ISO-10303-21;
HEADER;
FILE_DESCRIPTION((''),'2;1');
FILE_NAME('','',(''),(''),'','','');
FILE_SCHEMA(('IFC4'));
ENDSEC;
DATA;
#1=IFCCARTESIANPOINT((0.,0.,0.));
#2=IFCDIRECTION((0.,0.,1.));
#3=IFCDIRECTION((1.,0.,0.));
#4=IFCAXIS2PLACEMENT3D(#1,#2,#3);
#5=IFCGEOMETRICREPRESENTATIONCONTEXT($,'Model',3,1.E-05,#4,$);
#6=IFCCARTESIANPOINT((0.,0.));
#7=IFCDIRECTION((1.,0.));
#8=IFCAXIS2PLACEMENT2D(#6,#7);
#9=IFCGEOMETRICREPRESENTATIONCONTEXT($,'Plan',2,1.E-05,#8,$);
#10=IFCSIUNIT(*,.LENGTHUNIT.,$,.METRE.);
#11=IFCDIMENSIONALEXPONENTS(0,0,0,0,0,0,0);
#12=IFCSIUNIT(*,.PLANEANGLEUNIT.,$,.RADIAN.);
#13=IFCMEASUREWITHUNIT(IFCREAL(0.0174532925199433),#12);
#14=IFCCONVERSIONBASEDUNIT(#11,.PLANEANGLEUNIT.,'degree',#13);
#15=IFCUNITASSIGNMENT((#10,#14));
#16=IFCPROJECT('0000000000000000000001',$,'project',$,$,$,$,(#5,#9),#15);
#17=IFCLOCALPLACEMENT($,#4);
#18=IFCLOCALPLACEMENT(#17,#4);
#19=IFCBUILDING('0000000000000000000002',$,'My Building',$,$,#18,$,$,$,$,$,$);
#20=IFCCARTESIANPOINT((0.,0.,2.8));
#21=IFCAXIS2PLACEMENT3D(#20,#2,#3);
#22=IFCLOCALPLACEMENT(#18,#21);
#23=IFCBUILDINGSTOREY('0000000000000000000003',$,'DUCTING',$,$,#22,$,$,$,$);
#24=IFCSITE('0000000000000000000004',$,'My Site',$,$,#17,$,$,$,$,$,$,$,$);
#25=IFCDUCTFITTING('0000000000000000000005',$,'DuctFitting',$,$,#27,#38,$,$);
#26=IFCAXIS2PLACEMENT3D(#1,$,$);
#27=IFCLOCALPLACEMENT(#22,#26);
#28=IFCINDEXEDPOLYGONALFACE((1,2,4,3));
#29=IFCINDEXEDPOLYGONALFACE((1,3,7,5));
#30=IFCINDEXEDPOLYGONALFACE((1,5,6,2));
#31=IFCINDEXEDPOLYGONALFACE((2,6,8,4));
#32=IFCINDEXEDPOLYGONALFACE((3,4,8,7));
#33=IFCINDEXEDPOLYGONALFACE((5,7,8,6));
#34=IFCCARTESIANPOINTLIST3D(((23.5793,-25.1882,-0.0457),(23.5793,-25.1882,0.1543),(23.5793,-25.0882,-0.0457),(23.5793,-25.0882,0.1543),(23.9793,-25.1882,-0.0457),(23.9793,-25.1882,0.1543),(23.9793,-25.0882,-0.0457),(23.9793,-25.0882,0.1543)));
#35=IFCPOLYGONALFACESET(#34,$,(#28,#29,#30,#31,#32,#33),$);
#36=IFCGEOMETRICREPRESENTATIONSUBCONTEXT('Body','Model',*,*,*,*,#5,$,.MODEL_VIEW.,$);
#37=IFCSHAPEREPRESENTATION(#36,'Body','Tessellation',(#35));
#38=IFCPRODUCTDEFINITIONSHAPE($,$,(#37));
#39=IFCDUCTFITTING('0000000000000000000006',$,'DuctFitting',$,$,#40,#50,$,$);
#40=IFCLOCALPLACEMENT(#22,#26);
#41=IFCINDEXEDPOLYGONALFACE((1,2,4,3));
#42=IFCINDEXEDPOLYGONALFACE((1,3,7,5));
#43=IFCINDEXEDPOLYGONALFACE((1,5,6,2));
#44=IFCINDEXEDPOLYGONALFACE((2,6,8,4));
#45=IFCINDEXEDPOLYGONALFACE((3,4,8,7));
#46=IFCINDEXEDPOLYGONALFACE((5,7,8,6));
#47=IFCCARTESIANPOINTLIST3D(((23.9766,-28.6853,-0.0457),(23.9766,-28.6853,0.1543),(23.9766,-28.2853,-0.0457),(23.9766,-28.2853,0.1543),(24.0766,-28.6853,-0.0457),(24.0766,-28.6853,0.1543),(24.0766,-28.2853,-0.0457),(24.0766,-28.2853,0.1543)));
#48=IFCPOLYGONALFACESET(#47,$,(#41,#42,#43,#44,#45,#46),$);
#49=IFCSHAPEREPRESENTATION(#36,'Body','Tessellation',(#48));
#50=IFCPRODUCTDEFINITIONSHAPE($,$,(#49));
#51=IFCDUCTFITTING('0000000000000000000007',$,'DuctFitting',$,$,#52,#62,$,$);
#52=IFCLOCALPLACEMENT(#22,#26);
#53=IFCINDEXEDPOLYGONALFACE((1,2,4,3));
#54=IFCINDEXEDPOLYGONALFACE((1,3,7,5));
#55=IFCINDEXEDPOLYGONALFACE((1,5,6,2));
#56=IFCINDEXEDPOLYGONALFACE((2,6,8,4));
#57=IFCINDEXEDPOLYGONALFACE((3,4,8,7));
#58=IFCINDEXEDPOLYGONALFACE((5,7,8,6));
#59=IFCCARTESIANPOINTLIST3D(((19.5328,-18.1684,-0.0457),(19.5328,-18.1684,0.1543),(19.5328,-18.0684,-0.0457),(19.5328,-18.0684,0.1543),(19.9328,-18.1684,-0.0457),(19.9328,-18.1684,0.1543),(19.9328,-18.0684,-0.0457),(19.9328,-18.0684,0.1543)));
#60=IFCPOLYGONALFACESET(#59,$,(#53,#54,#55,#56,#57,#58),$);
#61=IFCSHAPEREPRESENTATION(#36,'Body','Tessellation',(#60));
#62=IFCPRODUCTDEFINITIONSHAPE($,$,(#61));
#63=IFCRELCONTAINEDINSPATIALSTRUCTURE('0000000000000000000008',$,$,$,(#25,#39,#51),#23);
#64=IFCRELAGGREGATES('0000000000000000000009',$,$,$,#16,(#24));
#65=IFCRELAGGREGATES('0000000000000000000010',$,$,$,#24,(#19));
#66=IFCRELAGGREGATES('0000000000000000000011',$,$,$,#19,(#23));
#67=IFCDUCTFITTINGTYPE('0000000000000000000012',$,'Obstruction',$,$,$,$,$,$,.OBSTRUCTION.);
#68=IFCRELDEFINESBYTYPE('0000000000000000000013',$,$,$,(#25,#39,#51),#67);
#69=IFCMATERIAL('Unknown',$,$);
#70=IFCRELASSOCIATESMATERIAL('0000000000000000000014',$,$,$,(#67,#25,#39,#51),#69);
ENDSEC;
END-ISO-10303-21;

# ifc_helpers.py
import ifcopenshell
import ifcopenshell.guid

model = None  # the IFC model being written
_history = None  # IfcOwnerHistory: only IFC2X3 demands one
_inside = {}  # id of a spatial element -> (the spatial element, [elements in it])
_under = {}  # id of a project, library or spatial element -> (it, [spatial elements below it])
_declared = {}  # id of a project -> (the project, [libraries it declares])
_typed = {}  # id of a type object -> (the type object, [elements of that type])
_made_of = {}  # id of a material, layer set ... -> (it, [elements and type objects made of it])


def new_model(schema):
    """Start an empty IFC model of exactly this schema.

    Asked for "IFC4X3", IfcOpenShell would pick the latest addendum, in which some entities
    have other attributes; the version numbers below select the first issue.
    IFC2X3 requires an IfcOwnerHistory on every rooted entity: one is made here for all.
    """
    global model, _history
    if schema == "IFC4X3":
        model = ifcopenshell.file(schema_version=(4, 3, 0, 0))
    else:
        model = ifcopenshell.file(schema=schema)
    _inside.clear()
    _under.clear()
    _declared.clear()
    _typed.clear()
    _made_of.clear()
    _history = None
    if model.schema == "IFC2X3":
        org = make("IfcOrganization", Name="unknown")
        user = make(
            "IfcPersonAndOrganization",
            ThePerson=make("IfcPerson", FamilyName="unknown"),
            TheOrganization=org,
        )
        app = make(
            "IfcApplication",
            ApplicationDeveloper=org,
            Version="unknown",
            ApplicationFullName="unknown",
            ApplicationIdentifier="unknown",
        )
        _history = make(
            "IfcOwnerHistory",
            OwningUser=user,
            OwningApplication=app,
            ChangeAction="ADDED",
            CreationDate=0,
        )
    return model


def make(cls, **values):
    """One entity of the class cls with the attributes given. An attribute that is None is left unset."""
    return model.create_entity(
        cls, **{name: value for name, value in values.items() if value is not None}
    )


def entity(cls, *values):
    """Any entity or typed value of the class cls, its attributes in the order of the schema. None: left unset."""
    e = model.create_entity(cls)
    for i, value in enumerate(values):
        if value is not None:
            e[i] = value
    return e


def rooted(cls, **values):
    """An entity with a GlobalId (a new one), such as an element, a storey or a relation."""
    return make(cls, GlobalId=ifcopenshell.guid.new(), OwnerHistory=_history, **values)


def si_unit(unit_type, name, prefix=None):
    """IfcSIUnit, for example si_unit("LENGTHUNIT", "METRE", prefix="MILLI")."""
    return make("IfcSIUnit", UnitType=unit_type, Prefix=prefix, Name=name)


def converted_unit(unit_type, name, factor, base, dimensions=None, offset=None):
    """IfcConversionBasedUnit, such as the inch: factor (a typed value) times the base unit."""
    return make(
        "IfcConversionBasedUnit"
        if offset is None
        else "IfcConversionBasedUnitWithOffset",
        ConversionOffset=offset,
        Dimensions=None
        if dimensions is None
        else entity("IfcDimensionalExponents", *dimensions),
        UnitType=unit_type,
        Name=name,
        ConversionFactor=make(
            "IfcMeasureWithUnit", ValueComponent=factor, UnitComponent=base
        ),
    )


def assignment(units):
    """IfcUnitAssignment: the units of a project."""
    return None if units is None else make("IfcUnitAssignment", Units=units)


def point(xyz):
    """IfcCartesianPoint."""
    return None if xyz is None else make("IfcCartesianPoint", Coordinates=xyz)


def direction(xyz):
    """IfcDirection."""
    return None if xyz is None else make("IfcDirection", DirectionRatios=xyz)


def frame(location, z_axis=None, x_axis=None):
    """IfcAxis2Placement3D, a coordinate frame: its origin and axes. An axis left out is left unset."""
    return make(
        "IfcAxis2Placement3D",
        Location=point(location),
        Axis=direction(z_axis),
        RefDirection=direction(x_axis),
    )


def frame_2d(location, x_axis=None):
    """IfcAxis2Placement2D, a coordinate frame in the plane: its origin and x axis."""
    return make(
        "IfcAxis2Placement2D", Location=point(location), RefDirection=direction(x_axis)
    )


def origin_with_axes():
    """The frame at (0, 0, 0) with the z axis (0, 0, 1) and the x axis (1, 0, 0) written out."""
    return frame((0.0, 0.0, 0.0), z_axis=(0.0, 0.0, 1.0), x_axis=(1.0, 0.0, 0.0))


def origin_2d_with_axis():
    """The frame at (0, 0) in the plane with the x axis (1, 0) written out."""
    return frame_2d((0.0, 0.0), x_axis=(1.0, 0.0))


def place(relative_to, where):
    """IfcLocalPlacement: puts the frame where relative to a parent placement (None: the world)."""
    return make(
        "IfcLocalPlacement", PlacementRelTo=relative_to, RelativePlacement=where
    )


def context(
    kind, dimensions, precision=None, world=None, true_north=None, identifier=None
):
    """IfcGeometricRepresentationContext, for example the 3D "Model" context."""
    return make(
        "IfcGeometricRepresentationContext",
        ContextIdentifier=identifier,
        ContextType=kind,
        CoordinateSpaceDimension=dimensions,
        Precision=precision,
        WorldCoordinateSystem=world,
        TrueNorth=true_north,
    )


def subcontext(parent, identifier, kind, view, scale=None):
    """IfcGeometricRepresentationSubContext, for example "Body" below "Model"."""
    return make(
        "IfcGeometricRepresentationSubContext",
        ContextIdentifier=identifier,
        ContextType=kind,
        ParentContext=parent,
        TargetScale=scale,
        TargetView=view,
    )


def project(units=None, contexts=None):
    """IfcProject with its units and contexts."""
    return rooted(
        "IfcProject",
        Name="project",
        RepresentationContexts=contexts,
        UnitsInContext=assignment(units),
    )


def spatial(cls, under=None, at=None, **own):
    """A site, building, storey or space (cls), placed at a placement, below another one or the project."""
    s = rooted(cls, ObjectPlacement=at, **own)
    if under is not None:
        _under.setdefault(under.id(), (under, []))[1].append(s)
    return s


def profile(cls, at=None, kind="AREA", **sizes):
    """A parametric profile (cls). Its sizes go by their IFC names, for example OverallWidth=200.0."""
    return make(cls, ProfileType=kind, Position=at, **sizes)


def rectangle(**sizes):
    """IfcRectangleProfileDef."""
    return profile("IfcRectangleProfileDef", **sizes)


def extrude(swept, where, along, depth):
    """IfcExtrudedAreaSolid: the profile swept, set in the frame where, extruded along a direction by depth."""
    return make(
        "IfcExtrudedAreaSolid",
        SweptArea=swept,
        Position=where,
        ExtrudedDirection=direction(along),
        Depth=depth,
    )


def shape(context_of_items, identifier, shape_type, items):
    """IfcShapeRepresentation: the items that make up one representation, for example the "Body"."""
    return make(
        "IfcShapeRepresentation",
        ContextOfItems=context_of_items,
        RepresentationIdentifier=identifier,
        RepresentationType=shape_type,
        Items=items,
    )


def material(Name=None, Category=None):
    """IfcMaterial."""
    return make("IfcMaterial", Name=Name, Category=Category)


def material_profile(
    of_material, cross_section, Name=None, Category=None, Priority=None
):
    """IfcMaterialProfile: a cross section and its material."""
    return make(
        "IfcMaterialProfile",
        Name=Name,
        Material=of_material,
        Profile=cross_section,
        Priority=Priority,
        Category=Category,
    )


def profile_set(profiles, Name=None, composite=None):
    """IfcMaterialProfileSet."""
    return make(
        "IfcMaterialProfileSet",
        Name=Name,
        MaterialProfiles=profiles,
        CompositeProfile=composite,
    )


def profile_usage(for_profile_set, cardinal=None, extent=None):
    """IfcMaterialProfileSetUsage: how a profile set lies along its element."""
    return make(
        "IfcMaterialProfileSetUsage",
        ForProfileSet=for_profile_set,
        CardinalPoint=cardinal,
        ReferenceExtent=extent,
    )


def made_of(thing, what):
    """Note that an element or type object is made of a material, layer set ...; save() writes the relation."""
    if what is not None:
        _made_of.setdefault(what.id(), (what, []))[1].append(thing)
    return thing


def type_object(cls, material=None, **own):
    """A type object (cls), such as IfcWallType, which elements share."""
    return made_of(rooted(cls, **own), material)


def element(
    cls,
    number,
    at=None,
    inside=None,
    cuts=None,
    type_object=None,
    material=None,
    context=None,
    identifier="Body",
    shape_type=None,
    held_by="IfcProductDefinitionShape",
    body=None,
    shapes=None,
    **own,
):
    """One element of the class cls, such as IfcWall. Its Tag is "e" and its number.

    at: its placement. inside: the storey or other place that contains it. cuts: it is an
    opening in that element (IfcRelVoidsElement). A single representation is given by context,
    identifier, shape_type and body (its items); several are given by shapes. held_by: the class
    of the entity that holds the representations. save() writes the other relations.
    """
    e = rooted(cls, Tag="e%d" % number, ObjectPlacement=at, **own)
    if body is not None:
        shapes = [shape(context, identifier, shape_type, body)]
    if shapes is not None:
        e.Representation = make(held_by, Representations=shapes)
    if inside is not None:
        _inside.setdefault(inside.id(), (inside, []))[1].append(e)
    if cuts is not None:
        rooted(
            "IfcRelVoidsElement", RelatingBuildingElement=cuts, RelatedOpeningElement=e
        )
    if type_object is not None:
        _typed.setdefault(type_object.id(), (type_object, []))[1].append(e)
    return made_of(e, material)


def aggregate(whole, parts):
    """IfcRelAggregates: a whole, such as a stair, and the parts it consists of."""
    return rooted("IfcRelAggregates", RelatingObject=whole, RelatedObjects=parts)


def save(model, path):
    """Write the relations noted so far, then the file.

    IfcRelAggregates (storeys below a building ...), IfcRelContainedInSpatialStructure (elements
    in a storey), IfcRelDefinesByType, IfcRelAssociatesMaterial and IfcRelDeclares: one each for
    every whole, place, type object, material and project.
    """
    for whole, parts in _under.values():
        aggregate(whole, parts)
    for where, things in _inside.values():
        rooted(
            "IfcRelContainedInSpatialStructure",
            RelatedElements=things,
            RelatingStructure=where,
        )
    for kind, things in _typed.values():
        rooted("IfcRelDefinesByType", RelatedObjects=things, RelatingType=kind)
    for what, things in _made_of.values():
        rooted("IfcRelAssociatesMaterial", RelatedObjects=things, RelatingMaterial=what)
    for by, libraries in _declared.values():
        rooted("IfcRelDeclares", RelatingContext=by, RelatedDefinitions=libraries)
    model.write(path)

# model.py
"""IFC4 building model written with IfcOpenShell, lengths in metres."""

from ifc_helpers import new_model, entity, si_unit, converted_unit, frame, origin_with_axes, origin_2d_with_axis, place, context, subcontext, project, spatial, rectangle, extrude, material, material_profile, profile_set, profile_usage, type_object, element, save


model = new_model("IFC4")

# Units and contexts
model_context = context("Model", 3, precision=1e-05, world=origin_with_axes())
plan_context = context("Plan", 2, precision=1e-05, world=origin_2d_with_axis())
body_context = subcontext(model_context, "Body", "Model", "MODEL_VIEW")
ifc_project = project(units=[si_unit("LENGTHUNIT", "METRE"), converted_unit("PLANEANGLEUNIT", "degree", entity("IfcReal", 0.0174532925199433), si_unit("PLANEANGLEUNIT", "RADIAN"), dimensions=[0, 0, 0, 0, 0, 0, 0])], contexts=[model_context, plan_context])

# Site, building, storey
site_placement = place(None, origin_with_axes())
site = spatial("IfcSite", under=ifc_project, at=site_placement, Name="My Site")
building_placement = place(site_placement, origin_with_axes())
building = spatial("IfcBuilding", under=site, at=building_placement, Name="My Building")
storey_placement = place(building_placement, frame((0.0, 0.0, 2.8), z_axis=(0.0, 0.0, 1.0), x_axis=(1.0, 0.0, 0.0)))
storey = spatial("IfcBuildingStorey", under=building, at=storey_placement, Name="DUCTING")

# Shared definitions
ifc_material = material(Name="Unknown")

# Duct fittings
ifc_material_profile_1 = material_profile(ifc_material, rectangle(XDim=0.4, YDim=0.2))
ifc_profile_set_1 = profile_set([ifc_material_profile_1])
duct_fitting_type_1 = type_object("IfcDuctFittingType", Name="Obstruction", PredefinedType="OBSTRUCTION", material=ifc_profile_set_1)
ifc_profile_usage_1 = profile_usage(ifc_profile_set_1, cardinal=5)
duct_fitting_1_placement = place(storey_placement, frame((23.7793, -25.1882, 0.0543), z_axis=(0.0, 1.0, 0.0), x_axis=(-1.0, 0.0, 0.0)))
element("IfcDuctFitting", 1, at=duct_fitting_1_placement, inside=storey, type_object=duct_fitting_type_1, material=ifc_profile_usage_1, Name="DuctFitting", context=body_context, shape_type="SweptSolid", body=[
    extrude(rectangle(XDim=0.4, YDim=0.2), origin_with_axes(), (0.0, 0.0, 1.0), 0.1),
])
ifc_profile_usage_2 = profile_usage(ifc_profile_set_1, cardinal=5)
duct_fitting_2_placement = place(storey_placement, frame((24.0766, -28.4853, 0.0543), z_axis=(-1.0, 0.0, 0.0), x_axis=(0.0, -1.0, 0.0)))
element("IfcDuctFitting", 2, at=duct_fitting_2_placement, inside=storey, type_object=duct_fitting_type_1, material=ifc_profile_usage_2, Name="DuctFitting", context=body_context, shape_type="SweptSolid", body=[
    extrude(rectangle(XDim=0.4, YDim=0.2), origin_with_axes(), (0.0, 0.0, 1.0), 0.1),
])
ifc_profile_usage_3 = profile_usage(ifc_profile_set_1, cardinal=5)
duct_fitting_3_placement = place(storey_placement, frame((19.7328, -18.1684, 0.0543), z_axis=(0.0, 1.0, 0.0), x_axis=(-1.0, 0.0, 0.0)))
element("IfcDuctFitting", 3, at=duct_fitting_3_placement, inside=storey, type_object=duct_fitting_type_1, material=ifc_profile_usage_3, Name="DuctFitting", context=body_context, shape_type="SweptSolid", body=[
    extrude(rectangle(XDim=0.4, YDim=0.2), origin_with_axes(), (0.0, 0.0, 1.0), 0.1),
])

save(model, "model.ifc")
